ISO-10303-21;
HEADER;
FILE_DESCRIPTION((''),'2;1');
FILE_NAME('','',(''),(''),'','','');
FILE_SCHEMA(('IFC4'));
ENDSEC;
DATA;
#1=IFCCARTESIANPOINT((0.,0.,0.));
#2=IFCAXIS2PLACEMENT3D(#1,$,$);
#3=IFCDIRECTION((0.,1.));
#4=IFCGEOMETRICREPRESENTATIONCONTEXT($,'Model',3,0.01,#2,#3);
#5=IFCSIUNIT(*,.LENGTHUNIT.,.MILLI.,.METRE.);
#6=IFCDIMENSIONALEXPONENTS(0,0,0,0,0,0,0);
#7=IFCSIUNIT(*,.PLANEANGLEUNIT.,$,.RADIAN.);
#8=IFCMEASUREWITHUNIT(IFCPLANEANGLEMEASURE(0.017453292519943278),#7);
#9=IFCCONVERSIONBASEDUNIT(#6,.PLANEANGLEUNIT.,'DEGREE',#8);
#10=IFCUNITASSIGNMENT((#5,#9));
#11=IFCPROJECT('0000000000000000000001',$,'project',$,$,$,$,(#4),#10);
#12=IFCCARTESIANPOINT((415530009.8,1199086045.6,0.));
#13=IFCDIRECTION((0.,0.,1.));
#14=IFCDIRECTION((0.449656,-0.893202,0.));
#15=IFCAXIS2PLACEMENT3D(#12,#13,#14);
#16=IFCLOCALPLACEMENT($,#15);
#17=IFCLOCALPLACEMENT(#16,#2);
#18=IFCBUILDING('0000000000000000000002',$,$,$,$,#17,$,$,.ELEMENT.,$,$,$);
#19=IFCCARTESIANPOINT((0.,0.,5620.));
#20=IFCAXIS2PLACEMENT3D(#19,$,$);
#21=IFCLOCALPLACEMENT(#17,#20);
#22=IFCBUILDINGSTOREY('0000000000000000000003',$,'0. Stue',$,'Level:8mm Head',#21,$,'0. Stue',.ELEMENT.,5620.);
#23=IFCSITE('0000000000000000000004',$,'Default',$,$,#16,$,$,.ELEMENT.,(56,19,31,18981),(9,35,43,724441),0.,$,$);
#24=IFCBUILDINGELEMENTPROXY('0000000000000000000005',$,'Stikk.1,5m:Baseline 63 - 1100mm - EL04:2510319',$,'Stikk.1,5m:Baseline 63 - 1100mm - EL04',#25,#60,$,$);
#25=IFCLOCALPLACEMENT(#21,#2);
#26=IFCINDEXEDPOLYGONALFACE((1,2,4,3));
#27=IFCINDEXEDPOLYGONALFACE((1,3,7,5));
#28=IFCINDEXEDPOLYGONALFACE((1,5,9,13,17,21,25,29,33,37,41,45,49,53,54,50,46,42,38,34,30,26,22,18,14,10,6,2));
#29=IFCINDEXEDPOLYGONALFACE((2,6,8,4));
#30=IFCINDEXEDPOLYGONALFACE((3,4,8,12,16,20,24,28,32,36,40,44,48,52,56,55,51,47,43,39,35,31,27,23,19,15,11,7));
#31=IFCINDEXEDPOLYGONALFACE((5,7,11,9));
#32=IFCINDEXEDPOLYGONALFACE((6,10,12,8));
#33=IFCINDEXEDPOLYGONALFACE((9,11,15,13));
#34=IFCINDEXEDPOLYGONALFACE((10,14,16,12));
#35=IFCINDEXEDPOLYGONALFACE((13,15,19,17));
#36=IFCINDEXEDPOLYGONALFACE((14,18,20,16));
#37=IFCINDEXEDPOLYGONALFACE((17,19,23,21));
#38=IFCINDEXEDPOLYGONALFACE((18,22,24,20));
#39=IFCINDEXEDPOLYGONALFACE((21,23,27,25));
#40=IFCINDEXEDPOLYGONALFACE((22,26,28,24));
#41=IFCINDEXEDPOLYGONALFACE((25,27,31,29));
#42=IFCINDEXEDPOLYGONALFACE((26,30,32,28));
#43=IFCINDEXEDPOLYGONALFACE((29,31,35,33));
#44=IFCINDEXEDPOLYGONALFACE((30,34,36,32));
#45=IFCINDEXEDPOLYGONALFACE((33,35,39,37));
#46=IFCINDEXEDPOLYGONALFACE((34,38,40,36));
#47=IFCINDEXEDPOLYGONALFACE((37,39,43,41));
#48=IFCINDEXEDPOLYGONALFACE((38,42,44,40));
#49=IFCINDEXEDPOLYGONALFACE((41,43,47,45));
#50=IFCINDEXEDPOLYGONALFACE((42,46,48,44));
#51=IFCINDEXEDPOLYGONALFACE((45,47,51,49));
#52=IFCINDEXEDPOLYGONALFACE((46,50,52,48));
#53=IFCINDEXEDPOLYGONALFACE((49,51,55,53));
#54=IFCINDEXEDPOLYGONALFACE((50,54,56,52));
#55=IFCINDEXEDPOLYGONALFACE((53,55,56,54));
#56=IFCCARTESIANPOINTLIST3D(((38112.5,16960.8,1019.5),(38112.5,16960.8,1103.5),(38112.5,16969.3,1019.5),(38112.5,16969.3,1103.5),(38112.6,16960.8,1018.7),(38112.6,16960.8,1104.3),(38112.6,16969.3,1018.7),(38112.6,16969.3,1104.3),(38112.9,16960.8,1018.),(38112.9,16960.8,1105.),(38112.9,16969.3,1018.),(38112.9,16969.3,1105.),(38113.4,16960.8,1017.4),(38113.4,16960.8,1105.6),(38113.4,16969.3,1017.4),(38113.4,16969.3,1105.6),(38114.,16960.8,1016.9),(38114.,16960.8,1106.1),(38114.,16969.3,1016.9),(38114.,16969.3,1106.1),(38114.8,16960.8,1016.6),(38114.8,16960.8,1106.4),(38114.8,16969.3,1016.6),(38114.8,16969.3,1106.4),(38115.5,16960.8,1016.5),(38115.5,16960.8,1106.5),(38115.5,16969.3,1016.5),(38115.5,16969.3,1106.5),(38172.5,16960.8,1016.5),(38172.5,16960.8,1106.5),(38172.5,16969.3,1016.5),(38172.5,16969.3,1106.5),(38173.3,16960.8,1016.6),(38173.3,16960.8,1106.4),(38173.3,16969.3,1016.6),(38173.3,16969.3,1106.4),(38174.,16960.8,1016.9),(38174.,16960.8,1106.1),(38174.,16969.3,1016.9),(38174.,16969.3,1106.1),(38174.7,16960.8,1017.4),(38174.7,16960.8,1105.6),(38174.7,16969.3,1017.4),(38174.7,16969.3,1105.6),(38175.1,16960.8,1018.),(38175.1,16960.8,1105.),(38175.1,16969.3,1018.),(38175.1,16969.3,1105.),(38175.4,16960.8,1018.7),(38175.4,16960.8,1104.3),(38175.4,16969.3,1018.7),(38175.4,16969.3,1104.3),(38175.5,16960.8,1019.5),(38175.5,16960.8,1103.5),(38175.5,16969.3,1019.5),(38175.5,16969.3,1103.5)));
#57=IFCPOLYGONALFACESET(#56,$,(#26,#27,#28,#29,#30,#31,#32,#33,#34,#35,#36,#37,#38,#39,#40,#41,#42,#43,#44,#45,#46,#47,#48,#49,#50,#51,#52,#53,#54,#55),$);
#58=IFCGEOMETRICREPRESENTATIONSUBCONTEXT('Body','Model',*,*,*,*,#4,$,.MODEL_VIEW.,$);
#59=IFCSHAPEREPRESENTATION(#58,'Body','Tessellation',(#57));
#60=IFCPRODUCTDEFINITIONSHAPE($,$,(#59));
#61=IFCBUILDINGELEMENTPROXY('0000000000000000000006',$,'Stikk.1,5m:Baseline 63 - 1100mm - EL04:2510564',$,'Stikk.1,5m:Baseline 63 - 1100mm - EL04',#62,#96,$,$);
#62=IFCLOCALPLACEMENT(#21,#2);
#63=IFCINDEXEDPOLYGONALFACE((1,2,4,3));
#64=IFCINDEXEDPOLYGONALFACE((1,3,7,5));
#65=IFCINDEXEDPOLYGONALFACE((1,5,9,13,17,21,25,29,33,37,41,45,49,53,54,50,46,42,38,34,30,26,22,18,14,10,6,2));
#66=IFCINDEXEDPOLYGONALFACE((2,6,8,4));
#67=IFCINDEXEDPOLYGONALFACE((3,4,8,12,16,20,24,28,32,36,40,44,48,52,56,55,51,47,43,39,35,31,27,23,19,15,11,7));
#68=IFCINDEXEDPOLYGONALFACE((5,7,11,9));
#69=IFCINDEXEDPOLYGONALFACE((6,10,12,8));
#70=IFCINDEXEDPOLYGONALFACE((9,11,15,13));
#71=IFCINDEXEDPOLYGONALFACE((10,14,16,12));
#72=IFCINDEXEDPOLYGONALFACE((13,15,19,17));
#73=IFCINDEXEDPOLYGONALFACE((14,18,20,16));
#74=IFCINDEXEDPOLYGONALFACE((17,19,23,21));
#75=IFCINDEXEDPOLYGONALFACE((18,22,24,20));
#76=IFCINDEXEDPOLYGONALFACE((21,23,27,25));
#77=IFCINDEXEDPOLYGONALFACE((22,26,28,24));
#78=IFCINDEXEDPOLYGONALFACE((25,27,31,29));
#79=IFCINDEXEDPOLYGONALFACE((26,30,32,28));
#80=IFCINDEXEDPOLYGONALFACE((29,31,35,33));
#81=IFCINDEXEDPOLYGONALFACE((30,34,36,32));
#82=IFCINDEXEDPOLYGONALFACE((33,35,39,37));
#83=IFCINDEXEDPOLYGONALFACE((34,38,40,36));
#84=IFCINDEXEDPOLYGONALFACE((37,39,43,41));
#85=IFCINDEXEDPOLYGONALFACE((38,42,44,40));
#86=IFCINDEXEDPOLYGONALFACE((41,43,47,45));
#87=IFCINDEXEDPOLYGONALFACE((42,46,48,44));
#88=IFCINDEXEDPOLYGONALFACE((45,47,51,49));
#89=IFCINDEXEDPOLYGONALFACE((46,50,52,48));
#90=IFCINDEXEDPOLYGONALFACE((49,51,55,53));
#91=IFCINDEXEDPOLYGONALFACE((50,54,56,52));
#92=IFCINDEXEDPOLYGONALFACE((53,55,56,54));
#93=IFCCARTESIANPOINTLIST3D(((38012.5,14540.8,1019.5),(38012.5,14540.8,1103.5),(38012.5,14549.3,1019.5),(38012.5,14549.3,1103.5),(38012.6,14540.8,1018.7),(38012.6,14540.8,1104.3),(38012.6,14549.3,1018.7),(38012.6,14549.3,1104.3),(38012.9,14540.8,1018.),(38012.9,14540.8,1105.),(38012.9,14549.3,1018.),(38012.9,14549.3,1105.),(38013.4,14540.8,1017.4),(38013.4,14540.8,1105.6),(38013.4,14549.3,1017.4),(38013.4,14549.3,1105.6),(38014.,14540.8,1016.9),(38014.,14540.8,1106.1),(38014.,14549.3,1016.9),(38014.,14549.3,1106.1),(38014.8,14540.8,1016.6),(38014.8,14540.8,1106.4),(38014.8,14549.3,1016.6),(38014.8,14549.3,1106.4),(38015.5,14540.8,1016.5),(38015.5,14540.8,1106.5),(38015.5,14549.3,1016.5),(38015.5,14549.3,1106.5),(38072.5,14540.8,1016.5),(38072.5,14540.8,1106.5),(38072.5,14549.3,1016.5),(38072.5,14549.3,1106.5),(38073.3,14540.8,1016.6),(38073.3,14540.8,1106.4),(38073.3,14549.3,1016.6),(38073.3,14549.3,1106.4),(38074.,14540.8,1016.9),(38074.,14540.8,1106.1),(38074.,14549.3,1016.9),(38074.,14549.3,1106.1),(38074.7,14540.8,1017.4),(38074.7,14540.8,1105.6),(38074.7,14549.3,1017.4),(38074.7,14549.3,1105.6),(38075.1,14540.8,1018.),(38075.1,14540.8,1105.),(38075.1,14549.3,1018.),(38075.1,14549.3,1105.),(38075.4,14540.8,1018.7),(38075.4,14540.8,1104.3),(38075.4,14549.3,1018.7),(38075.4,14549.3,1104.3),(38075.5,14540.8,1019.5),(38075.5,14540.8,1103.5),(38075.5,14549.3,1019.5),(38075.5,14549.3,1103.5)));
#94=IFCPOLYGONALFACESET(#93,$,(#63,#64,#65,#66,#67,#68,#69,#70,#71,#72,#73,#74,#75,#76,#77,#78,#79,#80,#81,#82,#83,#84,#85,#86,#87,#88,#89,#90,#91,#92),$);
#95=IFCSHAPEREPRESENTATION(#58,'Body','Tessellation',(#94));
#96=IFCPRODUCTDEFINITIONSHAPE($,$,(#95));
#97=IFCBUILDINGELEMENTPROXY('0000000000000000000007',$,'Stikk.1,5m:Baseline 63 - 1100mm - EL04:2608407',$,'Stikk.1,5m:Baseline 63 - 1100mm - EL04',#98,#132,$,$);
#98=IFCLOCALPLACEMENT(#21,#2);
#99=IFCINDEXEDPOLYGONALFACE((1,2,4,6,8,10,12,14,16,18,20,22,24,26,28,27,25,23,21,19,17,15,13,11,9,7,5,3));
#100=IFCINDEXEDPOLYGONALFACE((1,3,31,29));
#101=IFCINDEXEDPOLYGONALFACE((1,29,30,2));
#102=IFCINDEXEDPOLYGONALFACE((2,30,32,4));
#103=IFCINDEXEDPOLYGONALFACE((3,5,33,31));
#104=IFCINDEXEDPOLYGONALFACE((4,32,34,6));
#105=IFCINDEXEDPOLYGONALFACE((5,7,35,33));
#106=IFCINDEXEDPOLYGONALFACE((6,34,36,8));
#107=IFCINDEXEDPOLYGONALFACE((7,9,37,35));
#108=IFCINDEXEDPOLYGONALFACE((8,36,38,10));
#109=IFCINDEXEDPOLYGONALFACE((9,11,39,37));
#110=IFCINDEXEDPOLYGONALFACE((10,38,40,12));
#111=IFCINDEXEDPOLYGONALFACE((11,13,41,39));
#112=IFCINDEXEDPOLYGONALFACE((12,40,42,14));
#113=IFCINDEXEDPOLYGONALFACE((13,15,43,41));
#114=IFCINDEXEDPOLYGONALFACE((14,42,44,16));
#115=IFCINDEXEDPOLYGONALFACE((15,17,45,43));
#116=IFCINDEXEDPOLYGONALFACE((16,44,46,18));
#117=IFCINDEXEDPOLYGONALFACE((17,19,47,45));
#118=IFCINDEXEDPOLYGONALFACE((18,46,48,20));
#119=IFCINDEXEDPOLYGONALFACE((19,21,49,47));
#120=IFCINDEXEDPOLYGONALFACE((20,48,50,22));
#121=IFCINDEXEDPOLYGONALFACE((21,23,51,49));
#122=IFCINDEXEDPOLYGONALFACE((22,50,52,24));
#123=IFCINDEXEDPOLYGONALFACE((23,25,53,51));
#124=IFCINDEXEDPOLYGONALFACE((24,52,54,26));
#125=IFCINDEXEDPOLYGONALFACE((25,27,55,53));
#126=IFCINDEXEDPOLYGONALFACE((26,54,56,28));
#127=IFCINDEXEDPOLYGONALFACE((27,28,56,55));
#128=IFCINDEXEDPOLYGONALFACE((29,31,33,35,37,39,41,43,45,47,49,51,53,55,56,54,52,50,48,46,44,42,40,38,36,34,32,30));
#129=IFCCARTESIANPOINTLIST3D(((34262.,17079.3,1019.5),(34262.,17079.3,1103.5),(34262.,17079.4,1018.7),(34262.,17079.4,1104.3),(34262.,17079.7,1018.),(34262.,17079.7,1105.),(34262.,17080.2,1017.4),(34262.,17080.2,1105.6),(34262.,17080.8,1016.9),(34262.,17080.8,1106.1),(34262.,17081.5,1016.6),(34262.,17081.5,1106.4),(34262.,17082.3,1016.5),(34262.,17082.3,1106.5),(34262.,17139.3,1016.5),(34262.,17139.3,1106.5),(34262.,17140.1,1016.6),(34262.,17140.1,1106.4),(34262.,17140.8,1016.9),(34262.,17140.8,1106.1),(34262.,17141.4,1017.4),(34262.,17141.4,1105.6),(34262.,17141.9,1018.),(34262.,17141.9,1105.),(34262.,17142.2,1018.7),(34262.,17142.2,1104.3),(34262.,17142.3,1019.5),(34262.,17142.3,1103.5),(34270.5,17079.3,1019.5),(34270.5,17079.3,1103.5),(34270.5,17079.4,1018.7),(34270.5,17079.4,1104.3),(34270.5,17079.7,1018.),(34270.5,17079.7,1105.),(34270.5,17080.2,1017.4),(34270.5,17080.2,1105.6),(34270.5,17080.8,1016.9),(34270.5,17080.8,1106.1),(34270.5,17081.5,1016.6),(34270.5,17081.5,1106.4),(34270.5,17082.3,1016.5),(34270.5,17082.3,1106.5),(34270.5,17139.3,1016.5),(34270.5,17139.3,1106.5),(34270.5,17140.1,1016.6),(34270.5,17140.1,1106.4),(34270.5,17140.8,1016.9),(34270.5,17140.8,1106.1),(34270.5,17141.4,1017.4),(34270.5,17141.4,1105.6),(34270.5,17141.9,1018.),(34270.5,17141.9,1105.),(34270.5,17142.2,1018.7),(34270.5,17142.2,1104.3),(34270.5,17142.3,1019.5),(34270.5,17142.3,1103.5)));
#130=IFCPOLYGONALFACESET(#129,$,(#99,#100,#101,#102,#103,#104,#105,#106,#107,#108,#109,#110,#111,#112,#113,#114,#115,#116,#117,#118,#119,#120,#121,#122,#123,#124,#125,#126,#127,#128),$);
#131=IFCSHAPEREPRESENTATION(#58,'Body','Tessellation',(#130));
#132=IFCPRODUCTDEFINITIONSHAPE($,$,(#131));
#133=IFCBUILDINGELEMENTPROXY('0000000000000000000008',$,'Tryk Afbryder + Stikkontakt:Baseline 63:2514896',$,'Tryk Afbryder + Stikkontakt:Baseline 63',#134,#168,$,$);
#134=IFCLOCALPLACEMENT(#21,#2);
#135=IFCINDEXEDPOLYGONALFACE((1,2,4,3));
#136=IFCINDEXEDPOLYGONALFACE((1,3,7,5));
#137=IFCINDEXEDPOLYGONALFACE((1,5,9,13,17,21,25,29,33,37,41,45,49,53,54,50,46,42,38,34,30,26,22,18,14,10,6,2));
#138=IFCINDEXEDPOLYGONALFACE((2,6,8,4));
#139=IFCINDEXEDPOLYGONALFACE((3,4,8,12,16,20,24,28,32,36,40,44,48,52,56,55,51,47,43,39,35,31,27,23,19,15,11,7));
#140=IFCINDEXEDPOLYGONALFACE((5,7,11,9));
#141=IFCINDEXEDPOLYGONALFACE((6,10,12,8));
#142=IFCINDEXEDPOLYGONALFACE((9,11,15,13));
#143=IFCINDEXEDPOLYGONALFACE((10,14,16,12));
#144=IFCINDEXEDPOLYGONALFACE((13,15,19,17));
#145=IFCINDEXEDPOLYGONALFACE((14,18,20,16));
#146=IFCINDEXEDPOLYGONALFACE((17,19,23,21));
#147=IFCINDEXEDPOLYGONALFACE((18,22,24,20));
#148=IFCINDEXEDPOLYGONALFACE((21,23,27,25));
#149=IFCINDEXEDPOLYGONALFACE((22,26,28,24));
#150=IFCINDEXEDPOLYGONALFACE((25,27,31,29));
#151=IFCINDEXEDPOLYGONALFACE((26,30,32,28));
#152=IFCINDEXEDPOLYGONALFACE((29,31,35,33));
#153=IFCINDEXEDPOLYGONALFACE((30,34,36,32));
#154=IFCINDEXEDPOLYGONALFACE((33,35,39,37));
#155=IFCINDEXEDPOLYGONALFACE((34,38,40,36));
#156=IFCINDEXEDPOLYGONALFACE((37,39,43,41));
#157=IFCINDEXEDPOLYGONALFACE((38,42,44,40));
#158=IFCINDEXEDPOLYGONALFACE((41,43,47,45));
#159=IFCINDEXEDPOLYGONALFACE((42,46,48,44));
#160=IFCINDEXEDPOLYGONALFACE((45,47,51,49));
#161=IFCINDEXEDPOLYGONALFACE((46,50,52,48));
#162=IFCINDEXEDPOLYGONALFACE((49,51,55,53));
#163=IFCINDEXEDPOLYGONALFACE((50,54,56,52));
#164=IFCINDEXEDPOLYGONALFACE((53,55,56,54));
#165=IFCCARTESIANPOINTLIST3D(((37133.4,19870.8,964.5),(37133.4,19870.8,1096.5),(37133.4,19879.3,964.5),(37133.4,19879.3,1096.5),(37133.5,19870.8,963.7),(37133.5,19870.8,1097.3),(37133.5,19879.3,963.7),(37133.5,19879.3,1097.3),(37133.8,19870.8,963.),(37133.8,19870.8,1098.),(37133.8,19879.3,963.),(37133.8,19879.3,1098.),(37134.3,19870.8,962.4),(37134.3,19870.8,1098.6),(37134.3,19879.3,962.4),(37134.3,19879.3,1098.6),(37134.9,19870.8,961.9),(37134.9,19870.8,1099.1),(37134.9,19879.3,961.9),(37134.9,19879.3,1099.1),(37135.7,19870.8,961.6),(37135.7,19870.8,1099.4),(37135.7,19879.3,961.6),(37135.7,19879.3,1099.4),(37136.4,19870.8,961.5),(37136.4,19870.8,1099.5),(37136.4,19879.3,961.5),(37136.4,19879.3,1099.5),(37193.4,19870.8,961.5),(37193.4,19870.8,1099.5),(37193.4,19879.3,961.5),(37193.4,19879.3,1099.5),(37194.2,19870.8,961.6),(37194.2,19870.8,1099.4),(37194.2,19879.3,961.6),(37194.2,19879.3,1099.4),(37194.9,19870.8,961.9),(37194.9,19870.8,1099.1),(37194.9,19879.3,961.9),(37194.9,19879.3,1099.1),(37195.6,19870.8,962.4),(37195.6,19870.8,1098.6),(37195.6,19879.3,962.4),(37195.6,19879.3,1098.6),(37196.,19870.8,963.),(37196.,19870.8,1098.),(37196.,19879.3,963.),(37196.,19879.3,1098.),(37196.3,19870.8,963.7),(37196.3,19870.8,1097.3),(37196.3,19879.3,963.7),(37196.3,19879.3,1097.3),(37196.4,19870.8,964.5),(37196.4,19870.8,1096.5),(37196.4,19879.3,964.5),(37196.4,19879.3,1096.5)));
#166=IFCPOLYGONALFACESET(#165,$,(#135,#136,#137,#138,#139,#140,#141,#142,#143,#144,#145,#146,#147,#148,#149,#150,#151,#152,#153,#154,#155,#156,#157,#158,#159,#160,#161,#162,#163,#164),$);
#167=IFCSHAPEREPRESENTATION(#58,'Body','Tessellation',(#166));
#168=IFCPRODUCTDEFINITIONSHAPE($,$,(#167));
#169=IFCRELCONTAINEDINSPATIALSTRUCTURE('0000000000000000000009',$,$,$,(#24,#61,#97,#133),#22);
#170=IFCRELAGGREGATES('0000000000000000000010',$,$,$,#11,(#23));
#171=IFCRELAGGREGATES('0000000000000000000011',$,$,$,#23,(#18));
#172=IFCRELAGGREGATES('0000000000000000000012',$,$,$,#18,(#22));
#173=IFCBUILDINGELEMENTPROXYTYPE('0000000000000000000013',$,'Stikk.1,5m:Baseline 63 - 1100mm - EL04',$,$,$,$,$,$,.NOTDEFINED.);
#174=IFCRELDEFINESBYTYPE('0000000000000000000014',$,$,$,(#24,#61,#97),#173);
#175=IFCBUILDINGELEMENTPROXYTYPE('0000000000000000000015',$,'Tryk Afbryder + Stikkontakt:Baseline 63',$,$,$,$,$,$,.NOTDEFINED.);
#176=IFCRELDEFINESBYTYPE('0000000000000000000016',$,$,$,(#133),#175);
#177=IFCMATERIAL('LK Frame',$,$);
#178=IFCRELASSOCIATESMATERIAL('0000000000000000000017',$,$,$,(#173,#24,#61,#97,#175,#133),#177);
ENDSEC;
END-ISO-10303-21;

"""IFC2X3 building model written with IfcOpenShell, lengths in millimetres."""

from ifc_helpers import new_model, entity, si_unit, converted_unit, direction, frame, frame_2d, origin, place, context, subcontext, project, spatial, polyline, circle_curve, parameter, trimmed, segment, composite_curve, outline, extrude, source, transform, mapped, material, type_object, type_shapes, element, save


model = new_model("IFC2X3")

# Units and contexts
model_context = context("Model", 3, precision=0.01, world=origin(), true_north=direction((0.0, 1.0)))
body_context = subcontext(model_context, "Body", "Model", "MODEL_VIEW")
ifc_project = project(units=[si_unit("LENGTHUNIT", "METRE", prefix="MILLI"), converted_unit("PLANEANGLEUNIT", "DEGREE", entity("IfcPlaneAngleMeasure", 0.017453292519943278), si_unit("PLANEANGLEUNIT", "RADIAN"), dimensions=[0, 0, 0, 0, 0, 0, 0])], contexts=[model_context])

# Site, building, storey
site_placement = place(None, frame((415530009.8, 1199086045.6, 0.0), z_axis=(0.0, 0.0, 1.0), x_axis=(0.449656, -0.893202, 0.0)))
site = spatial("IfcSite", under=ifc_project, at=site_placement, Name="Default", CompositionType="ELEMENT", RefLatitude=(56, 19, 31, 18981), RefLongitude=(9, 35, 43, 724441), RefElevation=0.0)
building_placement = place(site_placement, origin())
building = spatial("IfcBuilding", under=site, at=building_placement, CompositionType="ELEMENT")
storey_placement = place(building_placement, frame((0.0, 0.0, 5620.0)))
storey = spatial("IfcBuildingStorey", under=building, at=storey_placement, Name="0. Stue", ObjectType="Level:8mm Head", LongName="0. Stue", CompositionType="ELEMENT", Elevation=5620.0)

# Building element proxies
ifc_material_1 = material(Name="LK Frame")
building_element_proxy_type_1 = type_object("IfcBuildingElementProxyType", Name="Stikk.1,5m:Baseline 63 - 1100mm - EL04", PredefinedType="NOTDEFINED", material=ifc_material_1)
shared_shape_1 = source(origin(), body_context, "Body", "SweptSolid", [
    extrude(outline(composite_curve([segment(polyline([(-42.0, -31.5), (42.0, -31.5)]), True, "CONTINUOUS"), segment(trimmed(circle_curve(frame_2d((42.0, -28.5), x_axis=(-1.0, 0.0)), 3.0), [parameter(90.0)], [parameter(180.0)], True, "PARAMETER"), True, "CONTINUOUS"), segment(polyline([(45.0, -28.5), (45.0, 28.5)]), True, "CONTINUOUS"), segment(trimmed(circle_curve(frame_2d((42.0, 28.5), x_axis=(-1.0, 0.0)), 3.0), [parameter(180.0)], [parameter(270.0)], True, "PARAMETER"), True, "CONTINUOUS"), segment(polyline([(42.0, 31.5), (-42.0, 31.5)]), True, "CONTINUOUS"), segment(trimmed(circle_curve(frame_2d((-42.0, 28.5), x_axis=(1.0, 0.0)), 3.0), [parameter(90.0)], [parameter(180.0)], True, "PARAMETER"), True, "CONTINUOUS"), segment(polyline([(-45.0, 28.5), (-45.0, -28.5)]), True, "CONTINUOUS"), segment(trimmed(circle_curve(frame_2d((-42.0, -28.5), x_axis=(1.0, 0.0)), 3.0), [parameter(180.0)], [parameter(270.0)], True, "PARAMETER"), True, "CONTINUOUS")], self_intersect=False)), frame((0.0, -38.5, 0.0), z_axis=(0.0, 0.0, 1.0), x_axis=(0.0, 1.0, 0.0)), (0.0, 0.0, 1.0), 8.5),
])
type_shapes(building_element_proxy_type_1, [shared_shape_1])
for number, where, z_axis, x_axis, name in (
    (1, (38144.0, 16960.8, 1100.0), (0.0, 1.0, 0.0), (-1.0, 0.0, 0.0), "Stikk.1,5m:Baseline 63 - 1100mm - EL04:2510319"),
    (2, (38044.0, 14540.8, 1100.0), (0.0, 1.0, 0.0), (-1.0, 0.0, 0.0), "Stikk.1,5m:Baseline 63 - 1100mm - EL04:2510564"),
    (3, (34270.5, 17110.8, 1100.0), (-1.0, 0.0, 0.0), (0.0, -1.0, 0.0), "Stikk.1,5m:Baseline 63 - 1100mm - EL04:2608407"),
):
    element("IfcBuildingElementProxy", number, at=place(storey_placement, frame(where, z_axis=z_axis, x_axis=x_axis)), inside=storey, type_object=building_element_proxy_type_1, material=ifc_material_1, Name=name, ObjectType="Stikk.1,5m:Baseline 63 - 1100mm - EL04", context=body_context, shape_type="MappedRepresentation", body=[
        mapped(shared_shape_1, transform((0.0, 0.0, 0.0), scale=1.0)),
    ])
building_element_proxy_type_2 = type_object("IfcBuildingElementProxyType", Name="Tryk Afbryder + Stikkontakt:Baseline 63", PredefinedType="NOTDEFINED", material=ifc_material_1)
shared_shape_2 = source(origin(), body_context, "Body", "SweptSolid", [
    extrude(outline(composite_curve([segment(polyline([(-66.0, -31.5), (66.0, -31.5)]), True, "CONTINUOUS"), segment(trimmed(circle_curve(frame_2d((66.0, -28.5), x_axis=(-1.0, 0.0)), 3.0), [parameter(90.0)], [parameter(180.0)], True, "PARAMETER"), True, "CONTINUOUS"), segment(polyline([(69.0, -28.5), (69.0, 28.5)]), True, "CONTINUOUS"), segment(trimmed(circle_curve(frame_2d((66.0, 28.5), x_axis=(-1.0, 0.0)), 3.0), [parameter(180.0)], [parameter(270.0)], True, "PARAMETER"), True, "CONTINUOUS"), segment(polyline([(66.0, 31.5), (-66.0, 31.5)]), True, "CONTINUOUS"), segment(trimmed(circle_curve(frame_2d((-66.0, 28.5), x_axis=(1.0, 0.0)), 3.0), [parameter(90.0)], [parameter(180.0)], True, "PARAMETER"), True, "CONTINUOUS"), segment(polyline([(-69.0, 28.5), (-69.0, -28.5)]), True, "CONTINUOUS"), segment(trimmed(circle_curve(frame_2d((-66.0, -28.5), x_axis=(1.0, 0.0)), 3.0), [parameter(180.0)], [parameter(270.0)], True, "PARAMETER"), True, "CONTINUOUS")], self_intersect=False)), frame((0.0, -69.5, 0.0), z_axis=(0.0, 0.0, 1.0), x_axis=(0.0, 1.0, 0.0)), (0.0, 0.0, 1.0), 8.5),
])
type_shapes(building_element_proxy_type_2, [shared_shape_2])
proxy_1_placement = place(storey_placement, frame((37164.9, 19870.8, 1100.0), z_axis=(0.0, 1.0, 0.0), x_axis=(-1.0, 0.0, 0.0)))
element("IfcBuildingElementProxy", 4, at=proxy_1_placement, inside=storey, type_object=building_element_proxy_type_2, material=ifc_material_1, Name="Tryk Afbryder + Stikkontakt:Baseline 63:2514896", ObjectType="Tryk Afbryder + Stikkontakt:Baseline 63", context=body_context, shape_type="MappedRepresentation", body=[
    mapped(shared_shape_2, transform((0.0, 0.0, 0.0), scale=1.0)),
])

save(model, "model.ifc")
